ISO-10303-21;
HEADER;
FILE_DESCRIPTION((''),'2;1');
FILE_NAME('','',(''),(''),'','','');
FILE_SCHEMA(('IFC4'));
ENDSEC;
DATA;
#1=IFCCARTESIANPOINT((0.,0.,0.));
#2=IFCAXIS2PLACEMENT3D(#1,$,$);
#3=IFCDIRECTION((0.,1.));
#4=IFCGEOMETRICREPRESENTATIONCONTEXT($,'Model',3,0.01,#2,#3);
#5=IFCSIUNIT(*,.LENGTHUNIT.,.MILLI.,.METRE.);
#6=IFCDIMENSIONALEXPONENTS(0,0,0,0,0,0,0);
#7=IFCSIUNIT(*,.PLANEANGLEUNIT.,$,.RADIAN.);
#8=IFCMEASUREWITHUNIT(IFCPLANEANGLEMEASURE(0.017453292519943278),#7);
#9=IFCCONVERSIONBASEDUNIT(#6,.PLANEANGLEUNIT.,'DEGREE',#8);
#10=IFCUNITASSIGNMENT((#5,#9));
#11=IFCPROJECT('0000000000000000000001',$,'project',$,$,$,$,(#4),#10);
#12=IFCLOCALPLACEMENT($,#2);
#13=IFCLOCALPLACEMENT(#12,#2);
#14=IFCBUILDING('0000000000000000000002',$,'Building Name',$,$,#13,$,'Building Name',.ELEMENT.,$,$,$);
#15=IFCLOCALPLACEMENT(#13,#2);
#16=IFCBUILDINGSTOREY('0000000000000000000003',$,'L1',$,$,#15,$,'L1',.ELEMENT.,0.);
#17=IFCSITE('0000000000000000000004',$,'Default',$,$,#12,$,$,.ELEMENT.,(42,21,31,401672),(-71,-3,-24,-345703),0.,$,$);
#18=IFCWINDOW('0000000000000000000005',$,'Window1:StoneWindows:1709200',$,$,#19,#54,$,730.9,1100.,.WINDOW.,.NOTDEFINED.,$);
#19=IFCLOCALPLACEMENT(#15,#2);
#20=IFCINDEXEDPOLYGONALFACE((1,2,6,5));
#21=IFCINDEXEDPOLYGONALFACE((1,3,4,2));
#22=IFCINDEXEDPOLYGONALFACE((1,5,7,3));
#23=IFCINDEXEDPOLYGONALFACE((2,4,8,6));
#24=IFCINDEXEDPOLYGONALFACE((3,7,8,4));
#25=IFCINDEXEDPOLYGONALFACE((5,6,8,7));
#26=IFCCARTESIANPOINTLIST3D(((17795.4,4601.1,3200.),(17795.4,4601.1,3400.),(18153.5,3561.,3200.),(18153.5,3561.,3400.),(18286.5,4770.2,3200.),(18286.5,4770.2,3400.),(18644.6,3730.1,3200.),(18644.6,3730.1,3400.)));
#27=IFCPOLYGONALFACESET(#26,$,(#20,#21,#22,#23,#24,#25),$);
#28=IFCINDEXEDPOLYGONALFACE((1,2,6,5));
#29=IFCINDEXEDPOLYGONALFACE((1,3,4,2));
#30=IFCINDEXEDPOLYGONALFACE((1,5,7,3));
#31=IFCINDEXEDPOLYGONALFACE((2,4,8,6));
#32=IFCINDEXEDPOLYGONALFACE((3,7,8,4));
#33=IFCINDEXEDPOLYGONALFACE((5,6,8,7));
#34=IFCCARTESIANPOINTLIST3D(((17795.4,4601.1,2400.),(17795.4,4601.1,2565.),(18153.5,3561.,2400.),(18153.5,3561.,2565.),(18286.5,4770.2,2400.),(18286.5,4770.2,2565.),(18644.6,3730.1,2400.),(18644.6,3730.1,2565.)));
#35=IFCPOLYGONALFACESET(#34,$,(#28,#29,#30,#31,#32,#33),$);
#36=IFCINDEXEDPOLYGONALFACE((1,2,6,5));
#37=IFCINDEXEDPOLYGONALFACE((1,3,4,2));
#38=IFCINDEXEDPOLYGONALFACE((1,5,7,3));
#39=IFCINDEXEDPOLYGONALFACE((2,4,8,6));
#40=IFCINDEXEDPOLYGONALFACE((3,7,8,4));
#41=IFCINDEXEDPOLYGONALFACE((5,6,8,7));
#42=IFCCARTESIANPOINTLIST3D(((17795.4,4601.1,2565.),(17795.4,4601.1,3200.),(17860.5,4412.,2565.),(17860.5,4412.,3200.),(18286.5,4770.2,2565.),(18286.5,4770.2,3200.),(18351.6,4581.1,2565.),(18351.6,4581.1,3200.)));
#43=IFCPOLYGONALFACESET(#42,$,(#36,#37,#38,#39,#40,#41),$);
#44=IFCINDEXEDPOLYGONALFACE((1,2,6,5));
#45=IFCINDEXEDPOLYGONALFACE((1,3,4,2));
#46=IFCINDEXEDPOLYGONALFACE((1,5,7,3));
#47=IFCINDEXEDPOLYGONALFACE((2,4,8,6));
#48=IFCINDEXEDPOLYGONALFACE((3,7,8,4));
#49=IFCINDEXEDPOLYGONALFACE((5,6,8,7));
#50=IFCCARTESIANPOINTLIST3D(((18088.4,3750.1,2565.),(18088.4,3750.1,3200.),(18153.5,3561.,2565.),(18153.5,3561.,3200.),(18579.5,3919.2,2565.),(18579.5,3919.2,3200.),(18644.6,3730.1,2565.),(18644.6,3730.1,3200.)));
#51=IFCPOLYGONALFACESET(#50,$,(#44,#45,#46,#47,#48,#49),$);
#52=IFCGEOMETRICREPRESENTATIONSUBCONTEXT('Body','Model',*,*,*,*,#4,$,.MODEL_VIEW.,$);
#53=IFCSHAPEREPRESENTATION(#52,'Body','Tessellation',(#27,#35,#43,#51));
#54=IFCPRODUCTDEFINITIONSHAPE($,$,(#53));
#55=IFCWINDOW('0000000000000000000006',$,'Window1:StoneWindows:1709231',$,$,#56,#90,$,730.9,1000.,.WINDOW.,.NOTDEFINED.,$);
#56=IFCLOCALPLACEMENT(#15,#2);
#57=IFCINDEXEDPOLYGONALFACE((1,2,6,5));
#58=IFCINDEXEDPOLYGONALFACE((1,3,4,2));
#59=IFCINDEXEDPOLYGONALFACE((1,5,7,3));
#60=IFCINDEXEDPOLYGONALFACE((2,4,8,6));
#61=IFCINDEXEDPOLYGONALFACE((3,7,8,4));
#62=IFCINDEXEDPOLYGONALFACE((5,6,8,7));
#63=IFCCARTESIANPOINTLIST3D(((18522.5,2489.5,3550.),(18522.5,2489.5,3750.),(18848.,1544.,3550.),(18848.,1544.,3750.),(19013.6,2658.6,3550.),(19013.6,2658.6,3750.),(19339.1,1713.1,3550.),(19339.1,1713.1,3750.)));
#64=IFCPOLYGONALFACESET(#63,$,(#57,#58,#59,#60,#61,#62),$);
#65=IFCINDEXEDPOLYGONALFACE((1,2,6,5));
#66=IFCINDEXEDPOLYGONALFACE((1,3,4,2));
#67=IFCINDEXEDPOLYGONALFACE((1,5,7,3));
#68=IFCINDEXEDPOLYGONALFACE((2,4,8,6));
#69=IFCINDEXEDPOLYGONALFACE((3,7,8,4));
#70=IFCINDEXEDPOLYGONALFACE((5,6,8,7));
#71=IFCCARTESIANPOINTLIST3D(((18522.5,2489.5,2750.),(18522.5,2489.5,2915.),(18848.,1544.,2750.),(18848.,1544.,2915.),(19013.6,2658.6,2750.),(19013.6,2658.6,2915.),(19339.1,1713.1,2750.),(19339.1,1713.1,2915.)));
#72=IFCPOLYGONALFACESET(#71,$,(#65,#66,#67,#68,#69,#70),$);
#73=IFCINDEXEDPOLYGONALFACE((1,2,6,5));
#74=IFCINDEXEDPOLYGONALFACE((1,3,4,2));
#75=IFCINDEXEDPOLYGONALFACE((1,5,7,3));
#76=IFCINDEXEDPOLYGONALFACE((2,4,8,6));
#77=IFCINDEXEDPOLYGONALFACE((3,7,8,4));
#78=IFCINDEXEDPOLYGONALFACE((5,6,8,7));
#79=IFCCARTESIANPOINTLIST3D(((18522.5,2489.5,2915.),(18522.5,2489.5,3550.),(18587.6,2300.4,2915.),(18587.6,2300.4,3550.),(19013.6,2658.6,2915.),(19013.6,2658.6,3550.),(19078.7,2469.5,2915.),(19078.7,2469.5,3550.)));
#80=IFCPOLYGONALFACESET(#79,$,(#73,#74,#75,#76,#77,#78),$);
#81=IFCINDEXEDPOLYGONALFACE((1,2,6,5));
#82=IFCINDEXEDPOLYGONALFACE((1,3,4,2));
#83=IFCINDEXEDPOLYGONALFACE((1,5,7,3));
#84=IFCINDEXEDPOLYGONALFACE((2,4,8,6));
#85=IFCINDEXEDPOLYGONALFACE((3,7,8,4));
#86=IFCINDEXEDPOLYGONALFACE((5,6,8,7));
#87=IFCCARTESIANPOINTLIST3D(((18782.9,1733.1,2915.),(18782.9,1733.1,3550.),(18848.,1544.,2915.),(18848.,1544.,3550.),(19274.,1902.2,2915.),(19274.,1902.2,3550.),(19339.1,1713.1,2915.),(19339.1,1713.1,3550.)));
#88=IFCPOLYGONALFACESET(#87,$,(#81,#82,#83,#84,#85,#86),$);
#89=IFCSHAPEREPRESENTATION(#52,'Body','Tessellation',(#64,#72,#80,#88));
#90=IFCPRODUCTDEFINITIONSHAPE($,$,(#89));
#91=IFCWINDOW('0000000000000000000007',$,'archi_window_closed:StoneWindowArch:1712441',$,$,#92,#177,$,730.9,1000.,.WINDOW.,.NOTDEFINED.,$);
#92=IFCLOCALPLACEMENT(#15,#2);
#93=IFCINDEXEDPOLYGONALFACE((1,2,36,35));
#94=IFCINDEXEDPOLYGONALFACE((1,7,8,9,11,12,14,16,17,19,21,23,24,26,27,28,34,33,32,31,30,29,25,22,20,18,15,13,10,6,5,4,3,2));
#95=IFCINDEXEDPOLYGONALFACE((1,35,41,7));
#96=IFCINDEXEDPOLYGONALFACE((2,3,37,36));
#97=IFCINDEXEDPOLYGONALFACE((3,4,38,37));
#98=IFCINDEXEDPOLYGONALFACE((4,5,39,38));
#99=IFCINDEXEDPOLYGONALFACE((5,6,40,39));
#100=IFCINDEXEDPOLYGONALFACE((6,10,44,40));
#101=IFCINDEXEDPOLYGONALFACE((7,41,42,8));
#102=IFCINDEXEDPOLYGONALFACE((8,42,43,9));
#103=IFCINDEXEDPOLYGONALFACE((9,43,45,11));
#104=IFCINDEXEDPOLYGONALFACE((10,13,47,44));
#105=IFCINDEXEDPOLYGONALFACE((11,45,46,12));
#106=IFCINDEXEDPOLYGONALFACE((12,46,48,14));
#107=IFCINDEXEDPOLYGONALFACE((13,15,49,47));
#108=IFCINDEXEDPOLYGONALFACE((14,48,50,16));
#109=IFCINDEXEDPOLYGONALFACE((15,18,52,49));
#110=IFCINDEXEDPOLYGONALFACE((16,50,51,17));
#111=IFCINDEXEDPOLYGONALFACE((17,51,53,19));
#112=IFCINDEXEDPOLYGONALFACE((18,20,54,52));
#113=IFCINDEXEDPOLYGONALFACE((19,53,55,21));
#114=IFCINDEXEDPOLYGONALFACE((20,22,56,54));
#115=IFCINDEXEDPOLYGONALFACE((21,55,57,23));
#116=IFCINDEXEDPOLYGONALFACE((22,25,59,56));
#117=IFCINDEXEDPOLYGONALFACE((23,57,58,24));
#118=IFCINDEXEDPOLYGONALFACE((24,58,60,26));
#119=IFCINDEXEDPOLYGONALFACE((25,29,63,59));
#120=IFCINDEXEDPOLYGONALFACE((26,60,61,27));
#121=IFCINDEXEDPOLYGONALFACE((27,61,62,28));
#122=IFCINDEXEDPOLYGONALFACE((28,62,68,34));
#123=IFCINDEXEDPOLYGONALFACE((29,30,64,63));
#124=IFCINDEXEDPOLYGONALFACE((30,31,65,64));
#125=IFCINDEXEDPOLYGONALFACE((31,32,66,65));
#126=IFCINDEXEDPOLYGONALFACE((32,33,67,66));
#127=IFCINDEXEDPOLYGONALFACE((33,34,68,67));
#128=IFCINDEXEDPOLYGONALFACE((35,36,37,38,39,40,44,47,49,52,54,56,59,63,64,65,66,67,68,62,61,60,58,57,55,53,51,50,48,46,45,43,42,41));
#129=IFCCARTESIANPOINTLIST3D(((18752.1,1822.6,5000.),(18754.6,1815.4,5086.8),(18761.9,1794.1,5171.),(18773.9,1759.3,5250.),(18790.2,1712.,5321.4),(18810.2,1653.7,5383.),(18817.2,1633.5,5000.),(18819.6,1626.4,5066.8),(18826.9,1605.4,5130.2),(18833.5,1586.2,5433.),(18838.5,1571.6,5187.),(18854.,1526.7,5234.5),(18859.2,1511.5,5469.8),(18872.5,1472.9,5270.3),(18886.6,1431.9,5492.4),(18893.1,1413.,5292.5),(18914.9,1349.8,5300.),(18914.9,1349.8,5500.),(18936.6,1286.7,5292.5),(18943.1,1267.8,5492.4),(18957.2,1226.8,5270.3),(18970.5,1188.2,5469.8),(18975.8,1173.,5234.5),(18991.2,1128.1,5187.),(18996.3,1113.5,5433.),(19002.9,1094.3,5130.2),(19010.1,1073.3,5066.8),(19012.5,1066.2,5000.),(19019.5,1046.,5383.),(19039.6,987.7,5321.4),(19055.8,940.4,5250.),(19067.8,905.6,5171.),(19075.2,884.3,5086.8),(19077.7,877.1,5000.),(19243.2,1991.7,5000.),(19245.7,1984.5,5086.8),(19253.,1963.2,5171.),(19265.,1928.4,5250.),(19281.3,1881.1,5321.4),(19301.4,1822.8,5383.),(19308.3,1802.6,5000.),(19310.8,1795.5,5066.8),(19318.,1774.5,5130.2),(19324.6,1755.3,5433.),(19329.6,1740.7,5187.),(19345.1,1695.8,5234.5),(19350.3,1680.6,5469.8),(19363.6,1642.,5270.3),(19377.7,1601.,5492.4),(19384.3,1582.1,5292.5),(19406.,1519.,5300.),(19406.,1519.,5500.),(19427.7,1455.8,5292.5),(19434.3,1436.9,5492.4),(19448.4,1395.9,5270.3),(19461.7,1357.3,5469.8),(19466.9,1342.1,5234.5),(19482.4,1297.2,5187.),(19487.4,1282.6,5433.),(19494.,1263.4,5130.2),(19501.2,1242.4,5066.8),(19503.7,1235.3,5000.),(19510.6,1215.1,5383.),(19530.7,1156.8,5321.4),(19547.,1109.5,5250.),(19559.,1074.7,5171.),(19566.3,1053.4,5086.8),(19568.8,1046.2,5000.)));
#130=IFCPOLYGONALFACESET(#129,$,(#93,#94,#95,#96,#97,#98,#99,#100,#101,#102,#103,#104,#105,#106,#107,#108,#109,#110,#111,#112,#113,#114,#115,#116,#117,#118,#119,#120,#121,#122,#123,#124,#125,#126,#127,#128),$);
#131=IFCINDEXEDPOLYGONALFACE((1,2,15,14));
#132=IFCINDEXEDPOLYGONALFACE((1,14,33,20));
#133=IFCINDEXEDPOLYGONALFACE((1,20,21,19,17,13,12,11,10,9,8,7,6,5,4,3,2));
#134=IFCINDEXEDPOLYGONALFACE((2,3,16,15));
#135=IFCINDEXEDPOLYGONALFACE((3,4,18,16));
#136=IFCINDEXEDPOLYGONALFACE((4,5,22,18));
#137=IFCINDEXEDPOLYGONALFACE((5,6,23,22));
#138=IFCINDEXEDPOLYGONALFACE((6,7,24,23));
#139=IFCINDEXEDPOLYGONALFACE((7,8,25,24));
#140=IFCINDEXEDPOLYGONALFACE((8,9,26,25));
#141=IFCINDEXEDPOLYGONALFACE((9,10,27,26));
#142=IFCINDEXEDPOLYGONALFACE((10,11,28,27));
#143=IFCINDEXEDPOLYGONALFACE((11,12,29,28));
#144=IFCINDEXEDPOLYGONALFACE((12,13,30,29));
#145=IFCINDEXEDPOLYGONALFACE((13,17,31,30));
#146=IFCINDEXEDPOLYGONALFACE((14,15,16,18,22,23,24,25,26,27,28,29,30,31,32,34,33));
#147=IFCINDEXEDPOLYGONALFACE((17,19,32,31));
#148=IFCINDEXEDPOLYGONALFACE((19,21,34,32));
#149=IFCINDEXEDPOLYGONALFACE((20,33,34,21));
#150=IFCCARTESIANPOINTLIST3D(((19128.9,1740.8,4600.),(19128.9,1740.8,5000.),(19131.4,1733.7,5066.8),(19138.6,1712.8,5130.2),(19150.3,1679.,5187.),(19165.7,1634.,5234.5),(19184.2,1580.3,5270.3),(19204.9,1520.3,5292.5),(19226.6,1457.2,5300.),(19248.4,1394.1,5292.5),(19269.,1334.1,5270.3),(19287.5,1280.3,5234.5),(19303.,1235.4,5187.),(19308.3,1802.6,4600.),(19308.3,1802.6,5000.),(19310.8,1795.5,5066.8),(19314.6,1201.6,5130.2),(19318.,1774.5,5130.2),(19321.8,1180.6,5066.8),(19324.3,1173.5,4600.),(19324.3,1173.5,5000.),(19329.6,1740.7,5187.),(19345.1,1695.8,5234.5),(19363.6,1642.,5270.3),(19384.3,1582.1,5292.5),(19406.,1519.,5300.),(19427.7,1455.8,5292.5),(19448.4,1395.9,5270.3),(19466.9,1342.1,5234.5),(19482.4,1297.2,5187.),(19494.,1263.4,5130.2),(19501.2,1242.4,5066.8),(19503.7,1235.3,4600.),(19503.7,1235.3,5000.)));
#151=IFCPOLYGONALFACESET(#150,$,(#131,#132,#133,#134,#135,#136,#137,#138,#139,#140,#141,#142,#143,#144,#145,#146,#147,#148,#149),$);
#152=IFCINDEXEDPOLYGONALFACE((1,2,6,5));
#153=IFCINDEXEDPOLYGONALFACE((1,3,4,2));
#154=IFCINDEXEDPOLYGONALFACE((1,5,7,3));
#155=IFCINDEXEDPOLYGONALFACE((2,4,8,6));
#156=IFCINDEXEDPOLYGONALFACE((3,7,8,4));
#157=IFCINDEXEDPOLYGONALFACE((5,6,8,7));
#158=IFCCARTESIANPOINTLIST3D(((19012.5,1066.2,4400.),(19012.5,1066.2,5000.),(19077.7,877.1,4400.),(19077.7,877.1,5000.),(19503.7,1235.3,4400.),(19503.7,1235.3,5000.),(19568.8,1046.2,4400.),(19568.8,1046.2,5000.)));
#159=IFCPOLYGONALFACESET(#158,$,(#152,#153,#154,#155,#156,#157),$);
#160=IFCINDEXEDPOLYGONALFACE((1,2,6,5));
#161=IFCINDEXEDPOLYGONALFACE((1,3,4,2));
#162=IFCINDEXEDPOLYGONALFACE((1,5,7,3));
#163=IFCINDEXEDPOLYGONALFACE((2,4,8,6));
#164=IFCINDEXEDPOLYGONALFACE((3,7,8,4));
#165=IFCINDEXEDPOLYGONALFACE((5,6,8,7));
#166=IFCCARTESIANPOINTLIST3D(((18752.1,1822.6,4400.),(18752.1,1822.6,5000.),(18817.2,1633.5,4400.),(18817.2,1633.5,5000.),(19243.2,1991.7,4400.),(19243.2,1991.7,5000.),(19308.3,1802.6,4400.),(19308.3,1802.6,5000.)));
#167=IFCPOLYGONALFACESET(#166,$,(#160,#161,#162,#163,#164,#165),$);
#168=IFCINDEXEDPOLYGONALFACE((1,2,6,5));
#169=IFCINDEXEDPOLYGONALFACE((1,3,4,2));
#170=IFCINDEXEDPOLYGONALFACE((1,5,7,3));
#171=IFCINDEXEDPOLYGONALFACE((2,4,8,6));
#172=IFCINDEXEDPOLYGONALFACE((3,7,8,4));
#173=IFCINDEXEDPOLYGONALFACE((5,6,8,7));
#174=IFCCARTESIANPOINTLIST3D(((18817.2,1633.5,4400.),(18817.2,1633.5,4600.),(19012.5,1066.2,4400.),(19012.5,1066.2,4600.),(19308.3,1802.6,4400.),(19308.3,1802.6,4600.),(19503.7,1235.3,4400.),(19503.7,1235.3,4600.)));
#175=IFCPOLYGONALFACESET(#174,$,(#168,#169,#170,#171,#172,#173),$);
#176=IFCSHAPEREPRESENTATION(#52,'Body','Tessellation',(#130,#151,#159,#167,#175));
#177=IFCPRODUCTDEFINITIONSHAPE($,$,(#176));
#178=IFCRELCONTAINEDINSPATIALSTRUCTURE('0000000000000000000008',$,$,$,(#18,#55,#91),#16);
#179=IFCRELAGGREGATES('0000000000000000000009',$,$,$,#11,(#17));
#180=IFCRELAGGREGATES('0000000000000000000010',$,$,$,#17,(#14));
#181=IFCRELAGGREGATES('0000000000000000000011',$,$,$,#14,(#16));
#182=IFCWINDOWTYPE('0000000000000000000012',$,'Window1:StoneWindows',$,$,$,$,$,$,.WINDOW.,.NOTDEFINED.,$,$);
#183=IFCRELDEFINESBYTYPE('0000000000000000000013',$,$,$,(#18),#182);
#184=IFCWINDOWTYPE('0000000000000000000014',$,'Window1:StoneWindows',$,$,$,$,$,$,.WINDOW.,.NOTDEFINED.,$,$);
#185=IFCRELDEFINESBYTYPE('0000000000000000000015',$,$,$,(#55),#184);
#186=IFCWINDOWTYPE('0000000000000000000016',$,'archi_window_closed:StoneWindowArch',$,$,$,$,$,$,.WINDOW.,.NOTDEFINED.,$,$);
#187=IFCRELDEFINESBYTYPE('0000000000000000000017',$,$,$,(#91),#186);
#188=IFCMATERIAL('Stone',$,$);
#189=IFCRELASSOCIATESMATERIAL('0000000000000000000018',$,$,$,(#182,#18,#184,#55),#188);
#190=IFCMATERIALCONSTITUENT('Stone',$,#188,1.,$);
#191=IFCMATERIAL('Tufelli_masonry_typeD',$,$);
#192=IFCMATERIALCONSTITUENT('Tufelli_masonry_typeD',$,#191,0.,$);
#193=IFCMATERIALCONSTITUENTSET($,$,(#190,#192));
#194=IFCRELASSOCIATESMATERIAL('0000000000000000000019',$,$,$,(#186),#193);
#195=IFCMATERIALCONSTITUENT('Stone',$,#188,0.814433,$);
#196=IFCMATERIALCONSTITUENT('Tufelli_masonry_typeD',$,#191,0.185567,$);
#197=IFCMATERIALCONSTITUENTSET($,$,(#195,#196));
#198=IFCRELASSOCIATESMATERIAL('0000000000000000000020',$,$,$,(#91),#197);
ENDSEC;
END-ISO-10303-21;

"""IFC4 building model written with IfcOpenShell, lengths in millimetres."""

from ifc_helpers import new_model, entity, si_unit, converted_unit, direction, frame, origin, place, context, subcontext, project, spatial, line, arc, indexed_curve, outline, extrude, source, transform, mapped, material, constituent, constituent_set, type_object, type_shapes, element, save


model = new_model("IFC4")

# Units and contexts
model_context = context("Model", 3, precision=0.01, world=origin(), true_north=direction((0.0, 1.0)))
body_context = subcontext(model_context, "Body", "Model", "MODEL_VIEW")
ifc_project = project(units=[si_unit("LENGTHUNIT", "METRE", prefix="MILLI"), converted_unit("PLANEANGLEUNIT", "DEGREE", entity("IfcPlaneAngleMeasure", 0.017453292519943278), si_unit("PLANEANGLEUNIT", "RADIAN"), dimensions=[0, 0, 0, 0, 0, 0, 0])], contexts=[model_context])

# Site, building, storey
site_placement = place(None, origin())
site = spatial("IfcSite", under=ifc_project, at=site_placement, Name="Default", CompositionType="ELEMENT", RefLatitude=(42, 21, 31, 401672), RefLongitude=(-71, -3, -24, -345703), RefElevation=0.0)
building_placement = place(site_placement, origin())
building = spatial("IfcBuilding", under=site, at=building_placement, Name="Building Name", LongName="Building Name", CompositionType="ELEMENT")
storey_placement = place(building_placement, origin())
storey = spatial("IfcBuildingStorey", under=building, at=storey_placement, Name="L1", LongName="L1", CompositionType="ELEMENT", Elevation=0.0)

# Shared definitions
ifc_material_1 = material(Name="Stone")

# Windows
window_type_1 = type_object("IfcWindowType", Name="Window1:StoneWindows", PartitioningType="NOTDEFINED", PredefinedType="WINDOW", material=ifc_material_1)
shared_shape_1 = source(origin(), body_context, "Body", "SweptSolid", [
    extrude(outline(indexed_curve([(-259.7, -550.0), (259.7, -550.0), (259.7, 550.0), (-259.7, 550.0), (-259.7, -550.0)], self_intersect=False)), frame((0.0, 0.0, 1600.0), z_axis=(0.0, 0.0, 1.0), x_axis=(0.0, 1.0, 0.0)), (0.0, 0.0, 1.0), 200.0),
    extrude(outline(indexed_curve([(-259.7, -550.0), (259.7, -550.0), (259.7, 550.0), (-259.7, 550.0), (-259.7, -550.0)], self_intersect=False)), frame((0.0, 0.0, 800.0), z_axis=(0.0, 0.0, 1.0), x_axis=(0.0, 1.0, 0.0)), (0.0, 0.0, 1.0), 165.0),
    extrude(outline(indexed_curve([(-259.7, -100.0), (259.7, -100.0), (259.7, 100.0), (-259.7, 100.0), (-259.7, -100.0)], self_intersect=False)), frame((-450.0, 0.0, 965.0), z_axis=(0.0, 0.0, 1.0), x_axis=(0.0, 1.0, 0.0)), (0.0, 0.0, 1.0), 635.0),
    extrude(outline(indexed_curve([(-259.7, -100.0), (259.7, -100.0), (259.7, 100.0), (-259.7, 100.0), (-259.7, -100.0)], self_intersect=False)), frame((450.0, 0.0, 965.0), z_axis=(0.0, 0.0, 1.0), x_axis=(0.0, 1.0, 0.0)), (0.0, 0.0, 1.0), 635.0),
])
type_shapes(window_type_1, [shared_shape_1])
window_1_placement = place(storey_placement, frame((18220.0, 4165.6, 1600.0), z_axis=(0.0, 0.0, 1.0), x_axis=(0.325568, -0.945519, 0.0)))
element("IfcWindow", 1, at=window_1_placement, inside=storey, type_object=window_type_1, material=ifc_material_1, Name="Window1:StoneWindows:1709200", OverallHeight=730.9, OverallWidth=1100.0, PartitioningType="NOTDEFINED", PredefinedType="WINDOW", context=body_context, shape_type="MappedRepresentation", body=[
    mapped(shared_shape_1, transform((0.0, 0.0, 0.0), scale=1.0)),
])
window_type_2 = type_object("IfcWindowType", Name="Window1:StoneWindows", PartitioningType="NOTDEFINED", PredefinedType="WINDOW", material=ifc_material_1)
shared_shape_2 = source(origin(), body_context, "Body", "SweptSolid", [
    extrude(outline(indexed_curve([(-259.7, -500.0), (259.7, -500.0), (259.7, 500.0), (-259.7, 500.0), (-259.7, -500.0)], self_intersect=False)), frame((0.0, 0.0, 1600.0), z_axis=(0.0, 0.0, 1.0), x_axis=(0.0, 1.0, 0.0)), (0.0, 0.0, 1.0), 200.0),
    extrude(outline(indexed_curve([(-259.7, -500.0), (259.7, -500.0), (259.7, 500.0), (-259.7, 500.0), (-259.7, -500.0)], self_intersect=False)), frame((0.0, 0.0, 800.0), z_axis=(0.0, 0.0, 1.0), x_axis=(0.0, 1.0, 0.0)), (0.0, 0.0, 1.0), 165.0),
    extrude(outline(indexed_curve([(-259.7, -100.0), (259.7, -100.0), (259.7, 100.0), (-259.7, 100.0), (-259.7, -100.0)], self_intersect=False)), frame((-400.0, 0.0, 965.0), z_axis=(0.0, 0.0, 1.0), x_axis=(0.0, 1.0, 0.0)), (0.0, 0.0, 1.0), 635.0),
    extrude(outline(indexed_curve([(-259.7, -100.0), (259.7, -100.0), (259.7, 100.0), (-259.7, 100.0), (-259.7, -100.0)], self_intersect=False)), frame((400.0, 0.0, 965.0), z_axis=(0.0, 0.0, 1.0), x_axis=(0.0, 1.0, 0.0)), (0.0, 0.0, 1.0), 635.0),
])
type_shapes(window_type_2, [shared_shape_2])
window_2_placement = place(storey_placement, frame((18930.8, 2101.3, 1950.0), z_axis=(0.0, 0.0, 1.0), x_axis=(0.325568, -0.945519, 0.0)))
element("IfcWindow", 2, at=window_2_placement, inside=storey, type_object=window_type_2, material=ifc_material_1, Name="Window1:StoneWindows:1709231", OverallHeight=730.9, OverallWidth=1000.0, PartitioningType="NOTDEFINED", PredefinedType="WINDOW", context=body_context, shape_type="MappedRepresentation", body=[
    mapped(shared_shape_2, transform((0.0, 0.0, 0.0), scale=1.0)),
])
ifc_constituent_1 = constituent(ifc_material_1, Name="Stone", fraction=0.814433)
ifc_material_2 = material(Name="Tufelli_masonry_typeD")
ifc_constituent_2 = constituent(ifc_material_2, Name="Tufelli_masonry_typeD", fraction=0.185567)
ifc_constituent_set_1 = constituent_set(constituents=[ifc_constituent_1, ifc_constituent_2])
ifc_constituent_3 = constituent(ifc_material_1, Name="Stone", fraction=1.0)
ifc_constituent_4 = constituent(ifc_material_2, Name="Tufelli_masonry_typeD", fraction=0.0)
ifc_constituent_set_2 = constituent_set(constituents=[ifc_constituent_3, ifc_constituent_4])
window_type_3 = type_object("IfcWindowType", Name="archi_window_closed:StoneWindowArch", PartitioningType="NOTDEFINED", PredefinedType="WINDOW", material=ifc_constituent_set_2)
shared_shape_3 = source(origin(), body_context, "Body", "SweptSolid", [
    extrude(outline(indexed_curve([(300.0, 0.0), (500.0, 0.0), (0.0, 500.0), (-500.0, 0.0), (-300.0, 0.0), (0.0, 300.0)], segments=[line(1, 2), arc(2, 3, 4), line(4, 5), arc(5, 6, 1)], self_intersect=False)), frame((0.0, -259.7, 1400.0), z_axis=(0.0, -1.0, 0.0), x_axis=(1.0, 0.0, 0.0)), (0.0, 0.0, -1.0), 519.4),
    extrude(outline(indexed_curve([(-200.0, -300.0), (200.0, -300.0), (200.0, 300.0), (-200.0, 300.0), (-500.0, 0.0)], segments=[line(1, 2, 3, 4), arc(4, 5, 1)], self_intersect=False)), frame((0.0, 70.0, 1200.0), z_axis=(0.0, 1.0, 0.0), x_axis=(0.0, 0.0, -1.0)), (0.0, 0.0, 1.0), 189.7),
    extrude(outline(indexed_curve([(-259.7, -100.0), (259.7, -100.0), (259.7, 100.0), (-259.7, 100.0), (-259.7, -100.0)], self_intersect=False)), frame((400.0, 0.0, 800.0), z_axis=(0.0, 0.0, 1.0), x_axis=(0.0, 1.0, 0.0)), (0.0, 0.0, 1.0), 600.0),
    extrude(outline(indexed_curve([(-259.7, -100.0), (259.7, -100.0), (259.7, 100.0), (-259.7, 100.0), (-259.7, -100.0)], self_intersect=False)), frame((-400.0, 0.0, 800.0), z_axis=(0.0, 0.0, 1.0), x_axis=(0.0, 1.0, 0.0)), (0.0, 0.0, 1.0), 600.0),
    extrude(outline(indexed_curve([(-259.7, -300.0), (259.7, -300.0), (259.7, 300.0), (-259.7, 300.0), (-259.7, -300.0)], self_intersect=False)), frame((0.0, 0.0, 800.0), z_axis=(0.0, 0.0, 1.0), x_axis=(0.0, 1.0, 0.0)), (0.0, 0.0, 1.0), 200.0),
])
type_shapes(window_type_3, [shared_shape_3])
window_3_placement = place(storey_placement, frame((19160.4, 1434.4, 3600.0), z_axis=(0.0, 0.0, 1.0), x_axis=(0.325568, -0.945519, 0.0)))
element("IfcWindow", 3, at=window_3_placement, inside=storey, type_object=window_type_3, material=ifc_constituent_set_1, Name="archi_window_closed:StoneWindowArch:1712441", OverallHeight=730.9, OverallWidth=1000.0, PartitioningType="NOTDEFINED", PredefinedType="WINDOW", context=body_context, shape_type="MappedRepresentation", body=[
    mapped(shared_shape_3, transform((0.0, 0.0, 0.0), scale=1.0)),
])

save(model, "model.ifc")
